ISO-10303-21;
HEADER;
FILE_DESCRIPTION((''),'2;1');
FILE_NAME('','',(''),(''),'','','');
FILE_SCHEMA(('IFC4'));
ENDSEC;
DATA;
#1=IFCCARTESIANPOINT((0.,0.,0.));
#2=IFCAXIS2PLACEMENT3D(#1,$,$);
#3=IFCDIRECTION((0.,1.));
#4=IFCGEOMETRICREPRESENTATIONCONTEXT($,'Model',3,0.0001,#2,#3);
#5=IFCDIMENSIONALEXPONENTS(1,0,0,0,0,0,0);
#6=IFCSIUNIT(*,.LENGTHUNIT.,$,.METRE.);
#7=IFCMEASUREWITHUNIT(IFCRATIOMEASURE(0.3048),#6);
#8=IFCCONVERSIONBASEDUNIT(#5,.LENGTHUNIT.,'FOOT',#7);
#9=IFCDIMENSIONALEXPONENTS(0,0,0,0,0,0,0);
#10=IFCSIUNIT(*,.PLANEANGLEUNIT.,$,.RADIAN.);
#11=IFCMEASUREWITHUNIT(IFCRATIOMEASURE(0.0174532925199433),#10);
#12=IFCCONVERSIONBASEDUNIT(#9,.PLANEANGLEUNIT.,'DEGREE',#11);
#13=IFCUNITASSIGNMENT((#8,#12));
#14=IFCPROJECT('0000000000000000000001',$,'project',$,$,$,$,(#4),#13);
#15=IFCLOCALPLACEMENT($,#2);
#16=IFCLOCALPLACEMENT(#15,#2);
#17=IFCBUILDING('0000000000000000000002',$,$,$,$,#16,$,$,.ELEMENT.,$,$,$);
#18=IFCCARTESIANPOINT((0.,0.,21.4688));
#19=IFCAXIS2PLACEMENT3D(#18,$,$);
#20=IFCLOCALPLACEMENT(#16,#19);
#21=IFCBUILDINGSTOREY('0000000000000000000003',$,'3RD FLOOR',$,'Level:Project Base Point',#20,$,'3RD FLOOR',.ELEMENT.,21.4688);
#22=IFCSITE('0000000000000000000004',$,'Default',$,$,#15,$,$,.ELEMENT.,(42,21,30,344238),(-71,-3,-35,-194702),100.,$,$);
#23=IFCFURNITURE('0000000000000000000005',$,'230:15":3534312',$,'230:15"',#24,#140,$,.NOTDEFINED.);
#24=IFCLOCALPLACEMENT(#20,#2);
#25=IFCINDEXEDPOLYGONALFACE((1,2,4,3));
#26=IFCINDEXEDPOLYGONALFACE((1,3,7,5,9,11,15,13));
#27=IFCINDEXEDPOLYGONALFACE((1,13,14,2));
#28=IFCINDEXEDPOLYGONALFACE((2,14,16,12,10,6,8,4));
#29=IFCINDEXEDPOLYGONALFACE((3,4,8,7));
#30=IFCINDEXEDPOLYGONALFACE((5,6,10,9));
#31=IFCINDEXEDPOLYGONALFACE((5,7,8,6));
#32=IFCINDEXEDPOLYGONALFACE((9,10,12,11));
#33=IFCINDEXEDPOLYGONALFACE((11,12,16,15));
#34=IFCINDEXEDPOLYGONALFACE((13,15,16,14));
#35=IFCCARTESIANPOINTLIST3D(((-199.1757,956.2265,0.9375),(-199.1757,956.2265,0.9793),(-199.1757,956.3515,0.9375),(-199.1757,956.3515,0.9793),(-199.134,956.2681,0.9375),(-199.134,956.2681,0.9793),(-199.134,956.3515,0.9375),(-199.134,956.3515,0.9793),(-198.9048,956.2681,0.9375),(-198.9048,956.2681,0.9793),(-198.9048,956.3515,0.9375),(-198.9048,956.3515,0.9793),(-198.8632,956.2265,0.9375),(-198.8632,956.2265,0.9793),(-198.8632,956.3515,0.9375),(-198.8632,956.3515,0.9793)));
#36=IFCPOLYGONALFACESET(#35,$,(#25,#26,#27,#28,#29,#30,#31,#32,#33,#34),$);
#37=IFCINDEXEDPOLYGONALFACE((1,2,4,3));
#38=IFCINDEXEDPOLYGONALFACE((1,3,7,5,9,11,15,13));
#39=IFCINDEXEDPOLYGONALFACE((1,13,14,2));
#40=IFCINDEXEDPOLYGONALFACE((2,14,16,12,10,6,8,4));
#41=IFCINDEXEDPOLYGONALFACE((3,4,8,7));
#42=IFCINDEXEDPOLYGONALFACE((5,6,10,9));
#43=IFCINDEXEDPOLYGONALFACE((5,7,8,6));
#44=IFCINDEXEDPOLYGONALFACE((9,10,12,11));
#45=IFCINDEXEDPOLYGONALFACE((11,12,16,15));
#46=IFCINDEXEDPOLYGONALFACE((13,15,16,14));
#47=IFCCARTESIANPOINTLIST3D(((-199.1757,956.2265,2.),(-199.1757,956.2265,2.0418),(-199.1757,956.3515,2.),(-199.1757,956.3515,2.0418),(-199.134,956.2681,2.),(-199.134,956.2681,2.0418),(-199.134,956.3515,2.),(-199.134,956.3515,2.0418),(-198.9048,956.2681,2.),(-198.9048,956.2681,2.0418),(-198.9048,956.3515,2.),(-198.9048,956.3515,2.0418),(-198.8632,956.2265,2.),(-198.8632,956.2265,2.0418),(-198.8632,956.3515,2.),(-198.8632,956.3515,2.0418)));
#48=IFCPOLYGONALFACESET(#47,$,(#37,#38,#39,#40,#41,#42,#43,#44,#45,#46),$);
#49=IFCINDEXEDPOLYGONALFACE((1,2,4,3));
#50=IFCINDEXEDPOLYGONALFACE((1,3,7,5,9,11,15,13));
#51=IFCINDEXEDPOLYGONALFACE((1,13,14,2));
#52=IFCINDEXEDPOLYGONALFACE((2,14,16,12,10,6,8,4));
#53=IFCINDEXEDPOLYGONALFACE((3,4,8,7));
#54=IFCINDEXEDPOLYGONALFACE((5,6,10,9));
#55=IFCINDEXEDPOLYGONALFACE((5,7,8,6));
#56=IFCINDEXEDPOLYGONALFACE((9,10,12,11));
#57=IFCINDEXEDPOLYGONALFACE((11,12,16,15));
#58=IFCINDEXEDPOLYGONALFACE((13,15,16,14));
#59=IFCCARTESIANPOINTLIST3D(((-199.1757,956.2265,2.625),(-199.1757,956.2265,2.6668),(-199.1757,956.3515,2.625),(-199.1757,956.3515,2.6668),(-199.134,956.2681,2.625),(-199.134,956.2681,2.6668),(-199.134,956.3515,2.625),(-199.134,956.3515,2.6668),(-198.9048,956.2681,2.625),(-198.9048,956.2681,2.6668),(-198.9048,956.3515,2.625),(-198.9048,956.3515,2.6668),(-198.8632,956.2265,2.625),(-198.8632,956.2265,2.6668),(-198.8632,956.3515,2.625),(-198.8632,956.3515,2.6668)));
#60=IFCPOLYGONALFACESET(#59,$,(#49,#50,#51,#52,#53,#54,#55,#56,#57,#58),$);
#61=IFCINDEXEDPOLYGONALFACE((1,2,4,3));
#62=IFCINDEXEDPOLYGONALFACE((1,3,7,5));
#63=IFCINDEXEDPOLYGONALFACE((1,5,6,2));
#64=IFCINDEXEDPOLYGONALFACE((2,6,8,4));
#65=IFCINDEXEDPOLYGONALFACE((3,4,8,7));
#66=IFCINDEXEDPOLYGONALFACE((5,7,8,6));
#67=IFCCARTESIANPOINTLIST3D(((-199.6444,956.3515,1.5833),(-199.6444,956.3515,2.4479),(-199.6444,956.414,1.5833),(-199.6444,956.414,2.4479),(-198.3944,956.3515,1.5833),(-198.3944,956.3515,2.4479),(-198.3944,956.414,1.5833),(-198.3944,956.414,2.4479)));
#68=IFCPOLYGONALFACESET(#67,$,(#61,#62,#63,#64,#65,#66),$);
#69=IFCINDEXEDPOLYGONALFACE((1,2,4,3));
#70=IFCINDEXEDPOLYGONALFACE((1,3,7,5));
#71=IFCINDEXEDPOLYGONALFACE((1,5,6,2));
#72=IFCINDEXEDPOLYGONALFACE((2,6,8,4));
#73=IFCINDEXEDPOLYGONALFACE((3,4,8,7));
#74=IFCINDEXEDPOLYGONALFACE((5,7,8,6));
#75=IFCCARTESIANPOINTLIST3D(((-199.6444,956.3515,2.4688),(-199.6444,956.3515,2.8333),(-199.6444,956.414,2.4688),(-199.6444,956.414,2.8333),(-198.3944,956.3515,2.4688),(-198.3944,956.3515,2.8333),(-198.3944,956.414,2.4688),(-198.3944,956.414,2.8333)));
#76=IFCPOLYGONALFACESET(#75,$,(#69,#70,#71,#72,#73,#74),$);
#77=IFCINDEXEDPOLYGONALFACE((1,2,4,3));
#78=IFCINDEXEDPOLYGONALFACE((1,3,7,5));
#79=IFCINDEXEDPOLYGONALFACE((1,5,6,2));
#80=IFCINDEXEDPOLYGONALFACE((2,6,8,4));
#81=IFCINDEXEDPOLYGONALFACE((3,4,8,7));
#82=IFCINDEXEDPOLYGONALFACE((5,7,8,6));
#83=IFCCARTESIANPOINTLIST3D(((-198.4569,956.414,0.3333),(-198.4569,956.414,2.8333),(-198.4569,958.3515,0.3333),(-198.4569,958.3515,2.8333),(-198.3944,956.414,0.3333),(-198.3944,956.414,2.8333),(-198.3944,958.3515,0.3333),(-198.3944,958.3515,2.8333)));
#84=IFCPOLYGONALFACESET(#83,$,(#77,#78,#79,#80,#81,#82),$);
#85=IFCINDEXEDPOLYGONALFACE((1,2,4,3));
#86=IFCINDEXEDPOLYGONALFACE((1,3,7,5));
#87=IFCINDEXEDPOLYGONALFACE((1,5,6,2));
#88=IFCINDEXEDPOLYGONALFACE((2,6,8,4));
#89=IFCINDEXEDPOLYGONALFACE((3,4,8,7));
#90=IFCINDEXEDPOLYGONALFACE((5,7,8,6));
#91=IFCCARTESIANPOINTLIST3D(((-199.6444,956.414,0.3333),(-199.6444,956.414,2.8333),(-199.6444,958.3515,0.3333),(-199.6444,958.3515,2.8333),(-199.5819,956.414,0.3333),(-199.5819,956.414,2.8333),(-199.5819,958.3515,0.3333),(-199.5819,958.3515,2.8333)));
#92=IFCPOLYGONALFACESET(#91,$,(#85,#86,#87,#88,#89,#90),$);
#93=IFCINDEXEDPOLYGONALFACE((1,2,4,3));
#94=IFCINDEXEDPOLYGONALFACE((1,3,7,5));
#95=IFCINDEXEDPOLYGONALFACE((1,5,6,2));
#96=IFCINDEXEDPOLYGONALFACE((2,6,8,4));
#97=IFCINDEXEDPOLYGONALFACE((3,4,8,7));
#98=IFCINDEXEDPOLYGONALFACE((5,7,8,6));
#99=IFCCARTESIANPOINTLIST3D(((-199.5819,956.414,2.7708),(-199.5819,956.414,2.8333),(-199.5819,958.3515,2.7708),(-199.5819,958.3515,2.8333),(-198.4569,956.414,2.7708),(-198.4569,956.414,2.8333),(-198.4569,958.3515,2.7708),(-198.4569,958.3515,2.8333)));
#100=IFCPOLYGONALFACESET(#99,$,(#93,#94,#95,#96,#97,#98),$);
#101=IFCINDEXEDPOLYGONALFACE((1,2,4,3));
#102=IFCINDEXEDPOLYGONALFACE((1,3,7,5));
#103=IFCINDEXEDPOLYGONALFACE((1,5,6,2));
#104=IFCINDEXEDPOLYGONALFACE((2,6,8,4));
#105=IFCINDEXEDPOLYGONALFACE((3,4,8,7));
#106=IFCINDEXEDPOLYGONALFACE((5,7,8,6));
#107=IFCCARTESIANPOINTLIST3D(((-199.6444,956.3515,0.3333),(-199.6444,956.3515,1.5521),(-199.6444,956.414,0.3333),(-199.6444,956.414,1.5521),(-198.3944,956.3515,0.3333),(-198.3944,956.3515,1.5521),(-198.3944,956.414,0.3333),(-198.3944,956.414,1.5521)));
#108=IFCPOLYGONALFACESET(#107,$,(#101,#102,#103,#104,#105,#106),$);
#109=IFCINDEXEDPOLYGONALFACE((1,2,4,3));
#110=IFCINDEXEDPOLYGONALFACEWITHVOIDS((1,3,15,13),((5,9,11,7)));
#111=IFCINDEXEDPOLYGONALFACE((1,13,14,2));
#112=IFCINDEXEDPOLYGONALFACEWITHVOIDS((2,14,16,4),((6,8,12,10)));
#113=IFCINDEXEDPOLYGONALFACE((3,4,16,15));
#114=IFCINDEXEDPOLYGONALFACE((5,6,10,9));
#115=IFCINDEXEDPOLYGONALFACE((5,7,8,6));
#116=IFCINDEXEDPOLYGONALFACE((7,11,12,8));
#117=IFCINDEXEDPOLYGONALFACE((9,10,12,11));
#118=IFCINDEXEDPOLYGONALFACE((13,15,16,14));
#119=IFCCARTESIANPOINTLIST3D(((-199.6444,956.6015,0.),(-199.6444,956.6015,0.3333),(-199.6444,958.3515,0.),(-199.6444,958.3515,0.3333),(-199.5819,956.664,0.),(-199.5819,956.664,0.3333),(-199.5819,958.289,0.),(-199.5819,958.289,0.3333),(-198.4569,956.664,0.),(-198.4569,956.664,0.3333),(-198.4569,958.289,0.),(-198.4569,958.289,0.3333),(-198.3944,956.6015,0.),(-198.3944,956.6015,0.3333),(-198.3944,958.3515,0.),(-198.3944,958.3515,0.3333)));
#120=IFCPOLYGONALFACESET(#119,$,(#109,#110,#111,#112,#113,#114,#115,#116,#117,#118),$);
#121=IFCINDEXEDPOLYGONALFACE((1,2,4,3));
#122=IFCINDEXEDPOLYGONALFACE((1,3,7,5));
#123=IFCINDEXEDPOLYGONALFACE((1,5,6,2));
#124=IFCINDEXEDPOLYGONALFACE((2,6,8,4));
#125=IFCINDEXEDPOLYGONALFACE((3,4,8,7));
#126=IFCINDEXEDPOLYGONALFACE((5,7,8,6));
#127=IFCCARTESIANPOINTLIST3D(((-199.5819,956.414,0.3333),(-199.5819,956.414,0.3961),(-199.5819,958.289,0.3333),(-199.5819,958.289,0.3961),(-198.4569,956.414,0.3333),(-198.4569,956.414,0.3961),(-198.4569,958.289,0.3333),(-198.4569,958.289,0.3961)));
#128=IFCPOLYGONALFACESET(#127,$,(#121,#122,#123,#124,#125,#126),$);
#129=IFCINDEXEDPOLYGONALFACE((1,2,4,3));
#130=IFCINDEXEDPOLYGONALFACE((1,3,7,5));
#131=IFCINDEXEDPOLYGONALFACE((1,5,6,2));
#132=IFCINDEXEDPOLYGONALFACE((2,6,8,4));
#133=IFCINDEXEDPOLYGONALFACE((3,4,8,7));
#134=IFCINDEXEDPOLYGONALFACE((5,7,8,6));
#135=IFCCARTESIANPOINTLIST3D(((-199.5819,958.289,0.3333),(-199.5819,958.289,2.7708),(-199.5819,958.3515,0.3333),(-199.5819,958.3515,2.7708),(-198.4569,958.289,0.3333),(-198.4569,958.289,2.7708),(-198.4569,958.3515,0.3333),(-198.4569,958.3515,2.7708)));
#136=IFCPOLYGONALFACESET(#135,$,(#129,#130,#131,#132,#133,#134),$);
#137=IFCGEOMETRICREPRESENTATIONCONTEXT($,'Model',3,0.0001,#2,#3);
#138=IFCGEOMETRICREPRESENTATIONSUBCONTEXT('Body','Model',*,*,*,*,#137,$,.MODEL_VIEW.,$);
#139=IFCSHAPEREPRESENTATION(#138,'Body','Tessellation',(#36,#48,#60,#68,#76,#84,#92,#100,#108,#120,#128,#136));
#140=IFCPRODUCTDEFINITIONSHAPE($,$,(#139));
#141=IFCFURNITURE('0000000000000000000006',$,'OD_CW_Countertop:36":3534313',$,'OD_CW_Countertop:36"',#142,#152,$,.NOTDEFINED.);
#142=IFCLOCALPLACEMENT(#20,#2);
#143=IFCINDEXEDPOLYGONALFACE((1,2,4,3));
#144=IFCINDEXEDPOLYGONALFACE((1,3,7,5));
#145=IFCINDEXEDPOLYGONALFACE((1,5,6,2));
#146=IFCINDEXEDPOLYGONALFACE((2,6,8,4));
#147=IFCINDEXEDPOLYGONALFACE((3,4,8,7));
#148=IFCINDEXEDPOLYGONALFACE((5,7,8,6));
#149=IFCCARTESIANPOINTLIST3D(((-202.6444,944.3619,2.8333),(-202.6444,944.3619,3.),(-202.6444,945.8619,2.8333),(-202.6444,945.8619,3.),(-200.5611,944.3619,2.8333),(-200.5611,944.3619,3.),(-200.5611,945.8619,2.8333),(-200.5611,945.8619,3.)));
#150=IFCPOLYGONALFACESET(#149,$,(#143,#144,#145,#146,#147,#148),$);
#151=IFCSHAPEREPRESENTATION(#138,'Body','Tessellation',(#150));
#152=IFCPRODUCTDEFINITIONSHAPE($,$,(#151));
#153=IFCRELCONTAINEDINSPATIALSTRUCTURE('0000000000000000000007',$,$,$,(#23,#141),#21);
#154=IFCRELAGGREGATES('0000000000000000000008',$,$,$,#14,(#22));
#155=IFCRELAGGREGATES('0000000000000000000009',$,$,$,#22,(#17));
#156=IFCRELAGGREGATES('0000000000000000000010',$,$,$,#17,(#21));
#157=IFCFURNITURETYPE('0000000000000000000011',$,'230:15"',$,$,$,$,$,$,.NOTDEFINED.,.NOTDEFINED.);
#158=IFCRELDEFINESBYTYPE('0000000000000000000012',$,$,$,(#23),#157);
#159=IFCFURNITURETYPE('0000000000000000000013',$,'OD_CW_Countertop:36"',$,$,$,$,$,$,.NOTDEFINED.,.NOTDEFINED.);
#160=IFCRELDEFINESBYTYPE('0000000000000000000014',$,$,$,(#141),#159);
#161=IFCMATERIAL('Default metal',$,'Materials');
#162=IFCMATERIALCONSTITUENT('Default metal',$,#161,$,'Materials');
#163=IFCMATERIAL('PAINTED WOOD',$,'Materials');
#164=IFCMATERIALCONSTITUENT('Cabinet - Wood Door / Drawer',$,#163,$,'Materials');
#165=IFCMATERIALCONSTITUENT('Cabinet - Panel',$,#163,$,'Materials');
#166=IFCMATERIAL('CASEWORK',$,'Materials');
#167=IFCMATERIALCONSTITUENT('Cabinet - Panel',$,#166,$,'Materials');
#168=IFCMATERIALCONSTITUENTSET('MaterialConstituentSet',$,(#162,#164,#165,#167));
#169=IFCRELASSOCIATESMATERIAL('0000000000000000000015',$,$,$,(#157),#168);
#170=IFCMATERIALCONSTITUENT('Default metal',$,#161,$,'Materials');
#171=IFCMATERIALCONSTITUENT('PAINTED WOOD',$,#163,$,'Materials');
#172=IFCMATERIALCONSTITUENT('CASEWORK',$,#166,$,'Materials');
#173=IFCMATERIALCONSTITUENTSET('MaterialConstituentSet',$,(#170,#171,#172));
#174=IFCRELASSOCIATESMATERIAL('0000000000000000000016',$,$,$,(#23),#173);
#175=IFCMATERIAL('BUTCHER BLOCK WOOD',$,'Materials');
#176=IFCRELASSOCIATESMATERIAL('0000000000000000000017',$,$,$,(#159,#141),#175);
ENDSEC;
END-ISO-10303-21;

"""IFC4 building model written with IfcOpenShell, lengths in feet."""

from ifc_helpers import new_model, entity, si_unit, converted_unit, direction, frame, frame_2d, origin, origin_2d_with_axis, place, context, subcontext, project, spatial, polyline, rectangle, outline, extrude, source, transform, mapped, material, constituent, constituent_set, type_object, type_shapes, element, save


model = new_model("IFC4")

# Units and contexts
model_context_1 = context("Model", 3, precision=0.0001, world=origin(), true_north=direction((0.0, 1.0)))
model_context_2 = context("Model", 3, precision=0.0001, world=origin(), true_north=direction((0.0, 1.0)))
body_context = subcontext(model_context_2, "Body", "Model", "MODEL_VIEW")
ifc_project = project(units=[converted_unit("LENGTHUNIT", "FOOT", entity("IfcRatioMeasure", 0.3048), si_unit("LENGTHUNIT", "METRE"), dimensions=[1, 0, 0, 0, 0, 0, 0]), converted_unit("PLANEANGLEUNIT", "DEGREE", entity("IfcRatioMeasure", 0.0174532925199433), si_unit("PLANEANGLEUNIT", "RADIAN"), dimensions=[0, 0, 0, 0, 0, 0, 0])], contexts=[model_context_1])

# Site, building, storey
site_placement = place(None, origin())
site = spatial("IfcSite", under=ifc_project, at=site_placement, Name="Default", CompositionType="ELEMENT", RefLatitude=(42, 21, 30, 344238), RefLongitude=(-71, -3, -35, -194702), RefElevation=100.0)
building_placement = place(site_placement, origin())
building = spatial("IfcBuilding", under=site, at=building_placement, CompositionType="ELEMENT")
storey_placement = place(building_placement, frame((0.0, 0.0, 21.4688)))
storey = spatial("IfcBuildingStorey", under=building, at=storey_placement, Name="3RD FLOOR", ObjectType="Level:Project Base Point", LongName="3RD FLOOR", CompositionType="ELEMENT", Elevation=21.4688)

# Furniture
ifc_material_1 = material(Name="CASEWORK", Category="Materials")
ifc_material_2 = material(Name="Default metal", Category="Materials")
ifc_material_3 = material(Name="PAINTED WOOD", Category="Materials")
ifc_material_4 = material(Name="BUTCHER BLOCK WOOD", Category="Materials")
ifc_constituent_1 = constituent(ifc_material_2, Name="Default metal", Category="Materials")
ifc_constituent_2 = constituent(ifc_material_3, Name="PAINTED WOOD", Category="Materials")
ifc_constituent_3 = constituent(ifc_material_1, Name="CASEWORK", Category="Materials")
ifc_constituent_set_1 = constituent_set(constituents=[ifc_constituent_1, ifc_constituent_2, ifc_constituent_3], Name="MaterialConstituentSet")
ifc_constituent_4 = constituent(ifc_material_2, Name="Default metal", Category="Materials")
ifc_constituent_5 = constituent(ifc_material_3, Name="Cabinet - Wood Door / Drawer", Category="Materials")
ifc_constituent_6 = constituent(ifc_material_3, Name="Cabinet - Panel", Category="Materials")
ifc_constituent_7 = constituent(ifc_material_1, Name="Cabinet - Panel", Category="Materials")
ifc_constituent_set_2 = constituent_set(constituents=[ifc_constituent_4, ifc_constituent_5, ifc_constituent_6, ifc_constituent_7], Name="MaterialConstituentSet")
furniture_type_1 = type_object("IfcFurnitureType", Name="230:15\"", AssemblyPlace="NOTDEFINED", PredefinedType="NOTDEFINED", material=ifc_constituent_set_2)
shared_shape_1 = source(origin(), body_context, "Body", "SweptSolid", [
    extrude(outline(polyline([(-0.1562, -0.0521), (-0.1146, -0.0521), (-0.1146, 0.0313), (0.1146, 0.0313), (0.1146, -0.0521), (0.1562, -0.0521), (0.1562, 0.0729), (-0.1562, 0.0729), (-0.1562, -0.0521)])), frame((0.0615, 2.0521, 0.9375)), (0.0, 0.0, 1.0), 0.0418),
    extrude(outline(polyline([(-0.1562, -0.0521), (-0.1146, -0.0521), (-0.1146, 0.0313), (0.1146, 0.0313), (0.1146, -0.0521), (0.1562, -0.0521), (0.1562, 0.0729), (-0.1562, 0.0729), (-0.1562, -0.0521)])), frame((0.0615, 2.0521, 2.0)), (0.0, 0.0, 1.0), 0.0418),
    extrude(outline(polyline([(-0.1562, -0.0521), (-0.1146, -0.0521), (-0.1146, 0.0313), (0.1146, 0.0313), (0.1146, -0.0521), (0.1562, -0.0521), (0.1562, 0.0729), (-0.1562, 0.0729), (-0.1562, -0.0521)])), frame((0.0615, 2.0521, 2.625)), (0.0, 0.0, 1.0), 0.0418),
    extrude(rectangle(XDim=1.25, YDim=0.0625, at=frame_2d((0.0, 0.0), x_axis=(1.0, 0.0))), frame((0.0615, 1.9688, 1.5833), z_axis=(0.0, 0.0, 1.0), x_axis=(-1.0, 0.0, 0.0)), (0.0, 0.0, 1.0), 0.8646),
    extrude(rectangle(XDim=1.25, YDim=0.0625, at=frame_2d((0.0, 0.0), x_axis=(1.0, 0.0))), frame((0.0615, 1.9688, 2.4688), z_axis=(0.0, 0.0, 1.0), x_axis=(-1.0, 0.0, 0.0)), (0.0, 0.0, 1.0), 0.3646),
    extrude(rectangle(XDim=1.9375, YDim=0.0625, at=frame_2d((0.0, 0.0), x_axis=(1.0, 0.0))), frame((-0.5323, 0.9687, 0.3333), z_axis=(0.0, 0.0, 1.0), x_axis=(0.0, -1.0, 0.0)), (0.0, 0.0, 1.0), 2.5),
    extrude(rectangle(XDim=1.9375, YDim=0.0625, at=frame_2d((0.0, 0.0), x_axis=(1.0, 0.0))), frame((0.6552, 0.9687, 0.3333), z_axis=(0.0, 0.0, 1.0), x_axis=(0.0, -1.0, 0.0)), (0.0, 0.0, 1.0), 2.5),
    extrude(rectangle(XDim=1.9375, YDim=1.125, at=origin_2d_with_axis()), frame((0.0615, 0.9687, 2.7708), z_axis=(0.0, 0.0, 1.0), x_axis=(0.0, 1.0, 0.0)), (0.0, 0.0, 1.0), 0.0625),
    extrude(rectangle(XDim=1.25, YDim=0.0625, at=frame_2d((0.0, 0.0), x_axis=(1.0, 0.0))), frame((0.0615, 1.9688, 0.3333), z_axis=(0.0, 0.0, 1.0), x_axis=(-1.0, 0.0, 0.0)), (0.0, 0.0, 1.0), 1.2187),
    extrude(outline(polyline([(-0.875, -0.625), (0.875, -0.625), (0.875, 0.625), (-0.875, 0.625), (-0.875, -0.625)]), holes=[polyline([(-0.8125, -0.5625), (-0.8125, 0.5625), (0.8125, 0.5625), (0.8125, -0.5625), (-0.8125, -0.5625)])]), frame((0.0615, 0.875, 0.0), z_axis=(0.0, 0.0, 1.0), x_axis=(0.0, -1.0, 0.0)), (0.0, 0.0, 1.0), 0.3333),
    extrude(rectangle(XDim=1.875, YDim=1.125, at=origin_2d_with_axis()), frame((0.0615, 1.0, 0.3333), z_axis=(0.0, 0.0, 1.0), x_axis=(0.0, 1.0, 0.0)), (0.0, 0.0, 1.0), 0.0627),
    extrude(rectangle(XDim=1.125, YDim=0.0625, at=origin_2d_with_axis()), frame((0.0615, 0.0312, 0.3333), z_axis=(0.0, 0.0, 1.0), x_axis=(-1.0, 0.0, 0.0)), (0.0, 0.0, 1.0), 2.4375),
])
type_shapes(furniture_type_1, [shared_shape_1])
furniture_1_placement = place(storey_placement, frame((-198.9579, 958.3515, 0.0), z_axis=(0.0, 0.0, 1.0), x_axis=(-1.0, 0.0, 0.0)))
element("IfcFurniture", 1, at=furniture_1_placement, inside=storey, type_object=furniture_type_1, material=ifc_constituent_set_1, Name="230:15\":3534312", ObjectType="230:15\"", PredefinedType="NOTDEFINED", context=body_context, shape_type="MappedRepresentation", body=[
    mapped(shared_shape_1, transform((0.0, 0.0, 0.0), scale=1.0)),
])
furniture_type_2 = type_object("IfcFurnitureType", Name="OD_CW_Countertop:36\"", AssemblyPlace="NOTDEFINED", PredefinedType="NOTDEFINED", material=ifc_material_4)
shared_shape_2 = source(origin(), body_context, "Body", "SweptSolid", [
    extrude(rectangle(XDim=2.0833, YDim=1.5, at=origin_2d_with_axis()), frame((0.75, 1.0417, 0.0), z_axis=(0.0, 0.0, 1.0), x_axis=(0.0, -1.0, 0.0)), (0.0, 0.0, 1.0), 0.1667),
])
type_shapes(furniture_type_2, [shared_shape_2])
furniture_2_placement = place(storey_placement, frame((-200.5611, 944.3619, 2.8333), z_axis=(0.0, 0.0, 1.0), x_axis=(0.0, 1.0, 0.0)))
element("IfcFurniture", 2, at=furniture_2_placement, inside=storey, type_object=furniture_type_2, material=ifc_material_4, Name="OD_CW_Countertop:36\":3534313", ObjectType="OD_CW_Countertop:36\"", PredefinedType="NOTDEFINED", context=body_context, shape_type="MappedRepresentation", body=[
    mapped(shared_shape_2, transform((0.0, 0.0, 0.0), scale=1.0)),
])

save(model, "model.ifc")
